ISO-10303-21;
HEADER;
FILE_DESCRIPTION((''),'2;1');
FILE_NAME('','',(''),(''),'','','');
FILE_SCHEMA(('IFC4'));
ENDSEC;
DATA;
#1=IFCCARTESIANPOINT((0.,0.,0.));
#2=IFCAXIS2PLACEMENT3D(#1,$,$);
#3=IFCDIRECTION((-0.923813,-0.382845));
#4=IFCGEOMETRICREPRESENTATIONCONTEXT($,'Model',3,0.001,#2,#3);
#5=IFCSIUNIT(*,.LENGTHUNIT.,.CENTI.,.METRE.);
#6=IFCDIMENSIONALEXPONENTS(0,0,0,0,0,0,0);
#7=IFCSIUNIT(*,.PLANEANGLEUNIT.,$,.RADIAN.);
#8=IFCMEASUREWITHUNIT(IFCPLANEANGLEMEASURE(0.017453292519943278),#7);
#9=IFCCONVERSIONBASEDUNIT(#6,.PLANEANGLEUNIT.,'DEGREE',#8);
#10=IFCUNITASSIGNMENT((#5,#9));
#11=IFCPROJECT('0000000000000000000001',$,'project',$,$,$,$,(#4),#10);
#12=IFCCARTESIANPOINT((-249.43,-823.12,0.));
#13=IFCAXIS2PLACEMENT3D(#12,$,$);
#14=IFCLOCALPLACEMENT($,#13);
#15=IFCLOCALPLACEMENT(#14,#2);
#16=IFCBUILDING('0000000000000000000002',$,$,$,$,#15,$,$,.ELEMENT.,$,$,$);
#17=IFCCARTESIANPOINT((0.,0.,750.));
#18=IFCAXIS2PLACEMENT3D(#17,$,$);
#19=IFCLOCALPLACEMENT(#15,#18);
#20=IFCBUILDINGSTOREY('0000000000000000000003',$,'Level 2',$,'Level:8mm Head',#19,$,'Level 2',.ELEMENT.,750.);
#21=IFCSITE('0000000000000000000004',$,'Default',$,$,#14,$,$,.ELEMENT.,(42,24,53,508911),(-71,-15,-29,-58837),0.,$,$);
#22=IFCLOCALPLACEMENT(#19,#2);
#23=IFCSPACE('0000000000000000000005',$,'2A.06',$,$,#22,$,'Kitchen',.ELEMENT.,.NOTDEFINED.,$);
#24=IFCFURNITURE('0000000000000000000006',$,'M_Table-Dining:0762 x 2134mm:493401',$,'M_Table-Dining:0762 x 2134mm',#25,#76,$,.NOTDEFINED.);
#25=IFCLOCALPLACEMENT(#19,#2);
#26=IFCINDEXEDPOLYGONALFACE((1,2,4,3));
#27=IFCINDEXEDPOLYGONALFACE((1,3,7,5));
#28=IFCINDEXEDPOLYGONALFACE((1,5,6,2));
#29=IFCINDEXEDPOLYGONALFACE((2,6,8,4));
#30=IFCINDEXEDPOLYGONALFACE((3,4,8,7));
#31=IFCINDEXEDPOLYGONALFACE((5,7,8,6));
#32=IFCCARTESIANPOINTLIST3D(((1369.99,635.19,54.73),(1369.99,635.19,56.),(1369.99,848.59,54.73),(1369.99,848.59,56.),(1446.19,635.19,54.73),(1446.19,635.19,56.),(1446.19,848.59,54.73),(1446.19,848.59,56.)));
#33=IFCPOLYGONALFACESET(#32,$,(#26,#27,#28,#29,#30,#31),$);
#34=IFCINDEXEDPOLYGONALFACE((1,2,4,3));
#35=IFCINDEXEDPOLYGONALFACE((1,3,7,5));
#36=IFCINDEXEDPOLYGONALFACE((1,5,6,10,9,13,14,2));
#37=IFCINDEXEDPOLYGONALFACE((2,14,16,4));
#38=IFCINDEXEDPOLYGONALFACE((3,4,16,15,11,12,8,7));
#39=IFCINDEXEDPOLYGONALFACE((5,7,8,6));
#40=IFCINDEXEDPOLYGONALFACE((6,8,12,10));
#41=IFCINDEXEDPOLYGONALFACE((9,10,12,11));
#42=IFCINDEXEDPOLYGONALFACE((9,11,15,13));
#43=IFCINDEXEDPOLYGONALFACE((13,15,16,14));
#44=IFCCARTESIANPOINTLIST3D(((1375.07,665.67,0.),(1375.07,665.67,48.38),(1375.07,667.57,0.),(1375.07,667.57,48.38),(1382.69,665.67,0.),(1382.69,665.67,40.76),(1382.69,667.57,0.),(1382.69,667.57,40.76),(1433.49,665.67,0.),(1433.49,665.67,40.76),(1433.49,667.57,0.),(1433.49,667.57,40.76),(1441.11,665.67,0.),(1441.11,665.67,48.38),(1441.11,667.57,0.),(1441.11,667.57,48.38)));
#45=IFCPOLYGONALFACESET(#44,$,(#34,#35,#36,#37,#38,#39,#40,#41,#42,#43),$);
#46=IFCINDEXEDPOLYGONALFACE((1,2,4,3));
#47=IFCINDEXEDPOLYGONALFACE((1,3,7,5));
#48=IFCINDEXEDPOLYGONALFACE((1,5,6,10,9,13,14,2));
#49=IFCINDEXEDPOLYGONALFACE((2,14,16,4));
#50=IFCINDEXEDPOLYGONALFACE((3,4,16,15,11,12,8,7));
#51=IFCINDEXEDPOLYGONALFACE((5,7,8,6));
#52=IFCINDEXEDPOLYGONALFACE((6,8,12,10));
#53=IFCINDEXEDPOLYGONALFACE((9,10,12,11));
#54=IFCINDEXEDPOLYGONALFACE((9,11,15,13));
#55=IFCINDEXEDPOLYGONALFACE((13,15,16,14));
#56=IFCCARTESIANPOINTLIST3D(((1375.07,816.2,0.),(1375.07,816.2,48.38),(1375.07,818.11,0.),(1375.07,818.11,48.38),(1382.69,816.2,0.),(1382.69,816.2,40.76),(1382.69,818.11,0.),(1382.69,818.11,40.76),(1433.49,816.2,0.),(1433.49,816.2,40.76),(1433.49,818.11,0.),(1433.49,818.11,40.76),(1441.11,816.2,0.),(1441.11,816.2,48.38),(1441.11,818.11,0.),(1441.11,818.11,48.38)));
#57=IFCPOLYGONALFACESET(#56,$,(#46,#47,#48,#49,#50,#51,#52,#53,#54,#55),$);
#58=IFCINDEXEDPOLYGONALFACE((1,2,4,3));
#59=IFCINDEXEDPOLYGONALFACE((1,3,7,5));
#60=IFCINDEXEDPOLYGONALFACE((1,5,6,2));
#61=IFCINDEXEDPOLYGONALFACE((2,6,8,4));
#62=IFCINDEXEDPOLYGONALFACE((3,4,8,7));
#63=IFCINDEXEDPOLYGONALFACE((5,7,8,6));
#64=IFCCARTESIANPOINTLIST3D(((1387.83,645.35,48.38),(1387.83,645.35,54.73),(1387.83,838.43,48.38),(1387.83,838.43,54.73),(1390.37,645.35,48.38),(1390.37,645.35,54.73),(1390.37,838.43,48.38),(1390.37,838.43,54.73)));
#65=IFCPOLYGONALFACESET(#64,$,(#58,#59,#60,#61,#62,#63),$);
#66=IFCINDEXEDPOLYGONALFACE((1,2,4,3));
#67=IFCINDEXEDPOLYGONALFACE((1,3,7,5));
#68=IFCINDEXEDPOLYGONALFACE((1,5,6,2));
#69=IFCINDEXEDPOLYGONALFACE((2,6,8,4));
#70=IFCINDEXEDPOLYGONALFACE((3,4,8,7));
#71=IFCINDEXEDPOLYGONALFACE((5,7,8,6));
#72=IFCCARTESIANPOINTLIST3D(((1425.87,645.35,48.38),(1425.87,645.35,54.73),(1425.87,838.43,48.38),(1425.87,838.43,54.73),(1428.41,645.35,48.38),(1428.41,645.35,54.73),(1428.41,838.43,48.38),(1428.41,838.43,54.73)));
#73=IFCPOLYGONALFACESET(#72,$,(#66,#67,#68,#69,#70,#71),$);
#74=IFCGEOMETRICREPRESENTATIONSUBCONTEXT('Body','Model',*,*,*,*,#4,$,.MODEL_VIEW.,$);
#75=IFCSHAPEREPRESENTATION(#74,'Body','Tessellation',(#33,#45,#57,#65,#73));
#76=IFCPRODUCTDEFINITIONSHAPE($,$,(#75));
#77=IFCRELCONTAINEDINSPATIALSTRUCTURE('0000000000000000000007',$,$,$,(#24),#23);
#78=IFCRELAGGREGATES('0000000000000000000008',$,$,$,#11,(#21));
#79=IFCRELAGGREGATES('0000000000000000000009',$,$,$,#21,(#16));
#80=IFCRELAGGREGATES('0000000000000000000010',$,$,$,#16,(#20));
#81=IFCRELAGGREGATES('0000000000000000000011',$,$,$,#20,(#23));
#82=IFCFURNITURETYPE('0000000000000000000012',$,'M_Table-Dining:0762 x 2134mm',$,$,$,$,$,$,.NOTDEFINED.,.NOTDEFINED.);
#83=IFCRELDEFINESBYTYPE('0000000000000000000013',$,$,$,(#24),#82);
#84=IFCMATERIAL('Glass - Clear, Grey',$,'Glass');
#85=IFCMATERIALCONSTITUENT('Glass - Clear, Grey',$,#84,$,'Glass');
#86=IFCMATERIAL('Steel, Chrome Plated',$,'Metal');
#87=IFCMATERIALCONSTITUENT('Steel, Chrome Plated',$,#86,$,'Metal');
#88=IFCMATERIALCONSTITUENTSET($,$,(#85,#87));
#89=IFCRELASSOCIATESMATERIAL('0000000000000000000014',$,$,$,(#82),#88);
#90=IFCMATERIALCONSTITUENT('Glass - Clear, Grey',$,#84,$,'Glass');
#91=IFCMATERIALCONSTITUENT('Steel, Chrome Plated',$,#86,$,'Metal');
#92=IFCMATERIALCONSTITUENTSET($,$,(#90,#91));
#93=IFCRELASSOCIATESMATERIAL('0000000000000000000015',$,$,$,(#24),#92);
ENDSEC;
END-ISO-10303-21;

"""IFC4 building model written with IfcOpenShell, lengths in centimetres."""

from ifc_helpers import new_model, entity, si_unit, converted_unit, direction, frame, origin, place, context, subcontext, project, spatial, indexed_curve, outline, extrude, source, transform, mapped, material, constituent, constituent_set, type_object, type_shapes, element, save


model = new_model("IFC4")

# Units and contexts
model_context = context("Model", 3, precision=0.001, world=origin(), true_north=direction((-0.923813, -0.382845)))
body_context = subcontext(model_context, "Body", "Model", "MODEL_VIEW")
ifc_project = project(units=[si_unit("LENGTHUNIT", "METRE", prefix="CENTI"), converted_unit("PLANEANGLEUNIT", "DEGREE", entity("IfcPlaneAngleMeasure", 0.017453292519943278), si_unit("PLANEANGLEUNIT", "RADIAN"), dimensions=[0, 0, 0, 0, 0, 0, 0])], contexts=[model_context])

# Site, building, storey
site_placement = place(None, frame((-249.43, -823.12, 0.0)))
site = spatial("IfcSite", under=ifc_project, at=site_placement, Name="Default", CompositionType="ELEMENT", RefLatitude=(42, 24, 53, 508911), RefLongitude=(-71, -15, -29, -58837), RefElevation=0.0)
building_placement = place(site_placement, origin())
building = spatial("IfcBuilding", under=site, at=building_placement, CompositionType="ELEMENT")
storey_placement = place(building_placement, frame((0.0, 0.0, 750.0)))
storey = spatial("IfcBuildingStorey", under=building, at=storey_placement, Name="Level 2", ObjectType="Level:8mm Head", LongName="Level 2", CompositionType="ELEMENT", Elevation=750.0)

# Shared definitions
space_1_placement = place(storey_placement, origin())
space_1 = spatial("IfcSpace", under=storey, at=space_1_placement, Name="2A.06", LongName="Kitchen", CompositionType="ELEMENT", PredefinedType="NOTDEFINED")

# Furniture
ifc_material_1 = material(Name="Glass - Clear, Grey", Category="Glass")
ifc_constituent_1 = constituent(ifc_material_1, Name="Glass - Clear, Grey", Category="Glass")
ifc_material_2 = material(Name="Steel, Chrome Plated", Category="Metal")
ifc_constituent_2 = constituent(ifc_material_2, Name="Steel, Chrome Plated", Category="Metal")
ifc_constituent_set_1 = constituent_set(constituents=[ifc_constituent_1, ifc_constituent_2])
ifc_constituent_3 = constituent(ifc_material_1, Name="Glass - Clear, Grey", Category="Glass")
ifc_constituent_4 = constituent(ifc_material_2, Name="Steel, Chrome Plated", Category="Metal")
ifc_constituent_set_2 = constituent_set(constituents=[ifc_constituent_3, ifc_constituent_4])
furniture_type_1 = type_object("IfcFurnitureType", Name="M_Table-Dining:0762 x 2134mm", AssemblyPlace="NOTDEFINED", PredefinedType="NOTDEFINED", material=ifc_constituent_set_2)
shared_shape_1 = source(origin(), body_context, "Body", "SweptSolid", [
    extrude(outline(indexed_curve([(-106.7, -38.1), (106.7, -38.1), (106.7, 38.1), (-106.7, 38.1), (-106.7, -38.1)], self_intersect=False)), frame((1.83, 9.52, 54.73), z_axis=(0.0, 0.0, 1.0), x_axis=(-1.0, 0.0, 0.0)), (0.0, 0.0, 1.0), 1.27),
    extrude(outline(indexed_curve([(-33.02, -26.09), (33.02, -26.09), (33.02, 22.28), (25.4, 22.28), (25.4, -18.47), (-25.4, -18.47), (-25.4, 22.28), (-33.02, 22.28), (-33.02, -26.09)], self_intersect=False)), frame((-74.39, 9.52, 22.28), z_axis=(1.0, 0.0, 0.0), x_axis=(0.0, -1.0, 0.0)), (0.0, 0.0, 1.0), 1.91),
    extrude(outline(indexed_curve([(-22.28, -33.02), (26.09, -33.02), (26.09, 33.02), (-22.28, 33.02), (-22.28, 25.4), (18.47, 25.4), (18.47, -25.4), (-22.28, -25.4), (-22.28, -33.02)], self_intersect=False)), frame((76.14, 9.52, 22.28), z_axis=(1.0, 0.0, 0.0), x_axis=(0.0, 0.0, 1.0)), (0.0, 0.0, 1.0), 1.91),
    extrude(outline(indexed_curve([(-96.54, -1.27), (96.54, -1.27), (96.54, 1.27), (-96.54, 1.27), (-96.54, -1.27)], self_intersect=False)), frame((1.83, 28.51, 48.38), z_axis=(0.0, 0.0, 1.0), x_axis=(-1.0, 0.0, 0.0)), (0.0, 0.0, 1.0), 6.35),
    extrude(outline(indexed_curve([(-96.54, -1.27), (96.54, -1.27), (96.54, 1.27), (-96.54, 1.27), (-96.54, -1.27)], self_intersect=False)), frame((1.83, -9.53, 48.38), z_axis=(0.0, 0.0, 1.0), x_axis=(-1.0, 0.0, 0.0)), (0.0, 0.0, 1.0), 6.35),
])
type_shapes(furniture_type_1, [shared_shape_1])
furniture_1_placement = place(space_1_placement, frame((1417.61, 740.06, 0.0), z_axis=(0.0, 0.0, 1.0), x_axis=(0.0, 1.0, 0.0)))
element("IfcFurniture", 1, at=furniture_1_placement, inside=space_1, type_object=furniture_type_1, material=ifc_constituent_set_1, Name="M_Table-Dining:0762 x 2134mm:493401", ObjectType="M_Table-Dining:0762 x 2134mm", PredefinedType="NOTDEFINED", context=body_context, shape_type="MappedRepresentation", body=[
    mapped(shared_shape_1, transform((0.0, 0.0, 0.0), scale=1.0)),
])

save(model, "model.ifc")
